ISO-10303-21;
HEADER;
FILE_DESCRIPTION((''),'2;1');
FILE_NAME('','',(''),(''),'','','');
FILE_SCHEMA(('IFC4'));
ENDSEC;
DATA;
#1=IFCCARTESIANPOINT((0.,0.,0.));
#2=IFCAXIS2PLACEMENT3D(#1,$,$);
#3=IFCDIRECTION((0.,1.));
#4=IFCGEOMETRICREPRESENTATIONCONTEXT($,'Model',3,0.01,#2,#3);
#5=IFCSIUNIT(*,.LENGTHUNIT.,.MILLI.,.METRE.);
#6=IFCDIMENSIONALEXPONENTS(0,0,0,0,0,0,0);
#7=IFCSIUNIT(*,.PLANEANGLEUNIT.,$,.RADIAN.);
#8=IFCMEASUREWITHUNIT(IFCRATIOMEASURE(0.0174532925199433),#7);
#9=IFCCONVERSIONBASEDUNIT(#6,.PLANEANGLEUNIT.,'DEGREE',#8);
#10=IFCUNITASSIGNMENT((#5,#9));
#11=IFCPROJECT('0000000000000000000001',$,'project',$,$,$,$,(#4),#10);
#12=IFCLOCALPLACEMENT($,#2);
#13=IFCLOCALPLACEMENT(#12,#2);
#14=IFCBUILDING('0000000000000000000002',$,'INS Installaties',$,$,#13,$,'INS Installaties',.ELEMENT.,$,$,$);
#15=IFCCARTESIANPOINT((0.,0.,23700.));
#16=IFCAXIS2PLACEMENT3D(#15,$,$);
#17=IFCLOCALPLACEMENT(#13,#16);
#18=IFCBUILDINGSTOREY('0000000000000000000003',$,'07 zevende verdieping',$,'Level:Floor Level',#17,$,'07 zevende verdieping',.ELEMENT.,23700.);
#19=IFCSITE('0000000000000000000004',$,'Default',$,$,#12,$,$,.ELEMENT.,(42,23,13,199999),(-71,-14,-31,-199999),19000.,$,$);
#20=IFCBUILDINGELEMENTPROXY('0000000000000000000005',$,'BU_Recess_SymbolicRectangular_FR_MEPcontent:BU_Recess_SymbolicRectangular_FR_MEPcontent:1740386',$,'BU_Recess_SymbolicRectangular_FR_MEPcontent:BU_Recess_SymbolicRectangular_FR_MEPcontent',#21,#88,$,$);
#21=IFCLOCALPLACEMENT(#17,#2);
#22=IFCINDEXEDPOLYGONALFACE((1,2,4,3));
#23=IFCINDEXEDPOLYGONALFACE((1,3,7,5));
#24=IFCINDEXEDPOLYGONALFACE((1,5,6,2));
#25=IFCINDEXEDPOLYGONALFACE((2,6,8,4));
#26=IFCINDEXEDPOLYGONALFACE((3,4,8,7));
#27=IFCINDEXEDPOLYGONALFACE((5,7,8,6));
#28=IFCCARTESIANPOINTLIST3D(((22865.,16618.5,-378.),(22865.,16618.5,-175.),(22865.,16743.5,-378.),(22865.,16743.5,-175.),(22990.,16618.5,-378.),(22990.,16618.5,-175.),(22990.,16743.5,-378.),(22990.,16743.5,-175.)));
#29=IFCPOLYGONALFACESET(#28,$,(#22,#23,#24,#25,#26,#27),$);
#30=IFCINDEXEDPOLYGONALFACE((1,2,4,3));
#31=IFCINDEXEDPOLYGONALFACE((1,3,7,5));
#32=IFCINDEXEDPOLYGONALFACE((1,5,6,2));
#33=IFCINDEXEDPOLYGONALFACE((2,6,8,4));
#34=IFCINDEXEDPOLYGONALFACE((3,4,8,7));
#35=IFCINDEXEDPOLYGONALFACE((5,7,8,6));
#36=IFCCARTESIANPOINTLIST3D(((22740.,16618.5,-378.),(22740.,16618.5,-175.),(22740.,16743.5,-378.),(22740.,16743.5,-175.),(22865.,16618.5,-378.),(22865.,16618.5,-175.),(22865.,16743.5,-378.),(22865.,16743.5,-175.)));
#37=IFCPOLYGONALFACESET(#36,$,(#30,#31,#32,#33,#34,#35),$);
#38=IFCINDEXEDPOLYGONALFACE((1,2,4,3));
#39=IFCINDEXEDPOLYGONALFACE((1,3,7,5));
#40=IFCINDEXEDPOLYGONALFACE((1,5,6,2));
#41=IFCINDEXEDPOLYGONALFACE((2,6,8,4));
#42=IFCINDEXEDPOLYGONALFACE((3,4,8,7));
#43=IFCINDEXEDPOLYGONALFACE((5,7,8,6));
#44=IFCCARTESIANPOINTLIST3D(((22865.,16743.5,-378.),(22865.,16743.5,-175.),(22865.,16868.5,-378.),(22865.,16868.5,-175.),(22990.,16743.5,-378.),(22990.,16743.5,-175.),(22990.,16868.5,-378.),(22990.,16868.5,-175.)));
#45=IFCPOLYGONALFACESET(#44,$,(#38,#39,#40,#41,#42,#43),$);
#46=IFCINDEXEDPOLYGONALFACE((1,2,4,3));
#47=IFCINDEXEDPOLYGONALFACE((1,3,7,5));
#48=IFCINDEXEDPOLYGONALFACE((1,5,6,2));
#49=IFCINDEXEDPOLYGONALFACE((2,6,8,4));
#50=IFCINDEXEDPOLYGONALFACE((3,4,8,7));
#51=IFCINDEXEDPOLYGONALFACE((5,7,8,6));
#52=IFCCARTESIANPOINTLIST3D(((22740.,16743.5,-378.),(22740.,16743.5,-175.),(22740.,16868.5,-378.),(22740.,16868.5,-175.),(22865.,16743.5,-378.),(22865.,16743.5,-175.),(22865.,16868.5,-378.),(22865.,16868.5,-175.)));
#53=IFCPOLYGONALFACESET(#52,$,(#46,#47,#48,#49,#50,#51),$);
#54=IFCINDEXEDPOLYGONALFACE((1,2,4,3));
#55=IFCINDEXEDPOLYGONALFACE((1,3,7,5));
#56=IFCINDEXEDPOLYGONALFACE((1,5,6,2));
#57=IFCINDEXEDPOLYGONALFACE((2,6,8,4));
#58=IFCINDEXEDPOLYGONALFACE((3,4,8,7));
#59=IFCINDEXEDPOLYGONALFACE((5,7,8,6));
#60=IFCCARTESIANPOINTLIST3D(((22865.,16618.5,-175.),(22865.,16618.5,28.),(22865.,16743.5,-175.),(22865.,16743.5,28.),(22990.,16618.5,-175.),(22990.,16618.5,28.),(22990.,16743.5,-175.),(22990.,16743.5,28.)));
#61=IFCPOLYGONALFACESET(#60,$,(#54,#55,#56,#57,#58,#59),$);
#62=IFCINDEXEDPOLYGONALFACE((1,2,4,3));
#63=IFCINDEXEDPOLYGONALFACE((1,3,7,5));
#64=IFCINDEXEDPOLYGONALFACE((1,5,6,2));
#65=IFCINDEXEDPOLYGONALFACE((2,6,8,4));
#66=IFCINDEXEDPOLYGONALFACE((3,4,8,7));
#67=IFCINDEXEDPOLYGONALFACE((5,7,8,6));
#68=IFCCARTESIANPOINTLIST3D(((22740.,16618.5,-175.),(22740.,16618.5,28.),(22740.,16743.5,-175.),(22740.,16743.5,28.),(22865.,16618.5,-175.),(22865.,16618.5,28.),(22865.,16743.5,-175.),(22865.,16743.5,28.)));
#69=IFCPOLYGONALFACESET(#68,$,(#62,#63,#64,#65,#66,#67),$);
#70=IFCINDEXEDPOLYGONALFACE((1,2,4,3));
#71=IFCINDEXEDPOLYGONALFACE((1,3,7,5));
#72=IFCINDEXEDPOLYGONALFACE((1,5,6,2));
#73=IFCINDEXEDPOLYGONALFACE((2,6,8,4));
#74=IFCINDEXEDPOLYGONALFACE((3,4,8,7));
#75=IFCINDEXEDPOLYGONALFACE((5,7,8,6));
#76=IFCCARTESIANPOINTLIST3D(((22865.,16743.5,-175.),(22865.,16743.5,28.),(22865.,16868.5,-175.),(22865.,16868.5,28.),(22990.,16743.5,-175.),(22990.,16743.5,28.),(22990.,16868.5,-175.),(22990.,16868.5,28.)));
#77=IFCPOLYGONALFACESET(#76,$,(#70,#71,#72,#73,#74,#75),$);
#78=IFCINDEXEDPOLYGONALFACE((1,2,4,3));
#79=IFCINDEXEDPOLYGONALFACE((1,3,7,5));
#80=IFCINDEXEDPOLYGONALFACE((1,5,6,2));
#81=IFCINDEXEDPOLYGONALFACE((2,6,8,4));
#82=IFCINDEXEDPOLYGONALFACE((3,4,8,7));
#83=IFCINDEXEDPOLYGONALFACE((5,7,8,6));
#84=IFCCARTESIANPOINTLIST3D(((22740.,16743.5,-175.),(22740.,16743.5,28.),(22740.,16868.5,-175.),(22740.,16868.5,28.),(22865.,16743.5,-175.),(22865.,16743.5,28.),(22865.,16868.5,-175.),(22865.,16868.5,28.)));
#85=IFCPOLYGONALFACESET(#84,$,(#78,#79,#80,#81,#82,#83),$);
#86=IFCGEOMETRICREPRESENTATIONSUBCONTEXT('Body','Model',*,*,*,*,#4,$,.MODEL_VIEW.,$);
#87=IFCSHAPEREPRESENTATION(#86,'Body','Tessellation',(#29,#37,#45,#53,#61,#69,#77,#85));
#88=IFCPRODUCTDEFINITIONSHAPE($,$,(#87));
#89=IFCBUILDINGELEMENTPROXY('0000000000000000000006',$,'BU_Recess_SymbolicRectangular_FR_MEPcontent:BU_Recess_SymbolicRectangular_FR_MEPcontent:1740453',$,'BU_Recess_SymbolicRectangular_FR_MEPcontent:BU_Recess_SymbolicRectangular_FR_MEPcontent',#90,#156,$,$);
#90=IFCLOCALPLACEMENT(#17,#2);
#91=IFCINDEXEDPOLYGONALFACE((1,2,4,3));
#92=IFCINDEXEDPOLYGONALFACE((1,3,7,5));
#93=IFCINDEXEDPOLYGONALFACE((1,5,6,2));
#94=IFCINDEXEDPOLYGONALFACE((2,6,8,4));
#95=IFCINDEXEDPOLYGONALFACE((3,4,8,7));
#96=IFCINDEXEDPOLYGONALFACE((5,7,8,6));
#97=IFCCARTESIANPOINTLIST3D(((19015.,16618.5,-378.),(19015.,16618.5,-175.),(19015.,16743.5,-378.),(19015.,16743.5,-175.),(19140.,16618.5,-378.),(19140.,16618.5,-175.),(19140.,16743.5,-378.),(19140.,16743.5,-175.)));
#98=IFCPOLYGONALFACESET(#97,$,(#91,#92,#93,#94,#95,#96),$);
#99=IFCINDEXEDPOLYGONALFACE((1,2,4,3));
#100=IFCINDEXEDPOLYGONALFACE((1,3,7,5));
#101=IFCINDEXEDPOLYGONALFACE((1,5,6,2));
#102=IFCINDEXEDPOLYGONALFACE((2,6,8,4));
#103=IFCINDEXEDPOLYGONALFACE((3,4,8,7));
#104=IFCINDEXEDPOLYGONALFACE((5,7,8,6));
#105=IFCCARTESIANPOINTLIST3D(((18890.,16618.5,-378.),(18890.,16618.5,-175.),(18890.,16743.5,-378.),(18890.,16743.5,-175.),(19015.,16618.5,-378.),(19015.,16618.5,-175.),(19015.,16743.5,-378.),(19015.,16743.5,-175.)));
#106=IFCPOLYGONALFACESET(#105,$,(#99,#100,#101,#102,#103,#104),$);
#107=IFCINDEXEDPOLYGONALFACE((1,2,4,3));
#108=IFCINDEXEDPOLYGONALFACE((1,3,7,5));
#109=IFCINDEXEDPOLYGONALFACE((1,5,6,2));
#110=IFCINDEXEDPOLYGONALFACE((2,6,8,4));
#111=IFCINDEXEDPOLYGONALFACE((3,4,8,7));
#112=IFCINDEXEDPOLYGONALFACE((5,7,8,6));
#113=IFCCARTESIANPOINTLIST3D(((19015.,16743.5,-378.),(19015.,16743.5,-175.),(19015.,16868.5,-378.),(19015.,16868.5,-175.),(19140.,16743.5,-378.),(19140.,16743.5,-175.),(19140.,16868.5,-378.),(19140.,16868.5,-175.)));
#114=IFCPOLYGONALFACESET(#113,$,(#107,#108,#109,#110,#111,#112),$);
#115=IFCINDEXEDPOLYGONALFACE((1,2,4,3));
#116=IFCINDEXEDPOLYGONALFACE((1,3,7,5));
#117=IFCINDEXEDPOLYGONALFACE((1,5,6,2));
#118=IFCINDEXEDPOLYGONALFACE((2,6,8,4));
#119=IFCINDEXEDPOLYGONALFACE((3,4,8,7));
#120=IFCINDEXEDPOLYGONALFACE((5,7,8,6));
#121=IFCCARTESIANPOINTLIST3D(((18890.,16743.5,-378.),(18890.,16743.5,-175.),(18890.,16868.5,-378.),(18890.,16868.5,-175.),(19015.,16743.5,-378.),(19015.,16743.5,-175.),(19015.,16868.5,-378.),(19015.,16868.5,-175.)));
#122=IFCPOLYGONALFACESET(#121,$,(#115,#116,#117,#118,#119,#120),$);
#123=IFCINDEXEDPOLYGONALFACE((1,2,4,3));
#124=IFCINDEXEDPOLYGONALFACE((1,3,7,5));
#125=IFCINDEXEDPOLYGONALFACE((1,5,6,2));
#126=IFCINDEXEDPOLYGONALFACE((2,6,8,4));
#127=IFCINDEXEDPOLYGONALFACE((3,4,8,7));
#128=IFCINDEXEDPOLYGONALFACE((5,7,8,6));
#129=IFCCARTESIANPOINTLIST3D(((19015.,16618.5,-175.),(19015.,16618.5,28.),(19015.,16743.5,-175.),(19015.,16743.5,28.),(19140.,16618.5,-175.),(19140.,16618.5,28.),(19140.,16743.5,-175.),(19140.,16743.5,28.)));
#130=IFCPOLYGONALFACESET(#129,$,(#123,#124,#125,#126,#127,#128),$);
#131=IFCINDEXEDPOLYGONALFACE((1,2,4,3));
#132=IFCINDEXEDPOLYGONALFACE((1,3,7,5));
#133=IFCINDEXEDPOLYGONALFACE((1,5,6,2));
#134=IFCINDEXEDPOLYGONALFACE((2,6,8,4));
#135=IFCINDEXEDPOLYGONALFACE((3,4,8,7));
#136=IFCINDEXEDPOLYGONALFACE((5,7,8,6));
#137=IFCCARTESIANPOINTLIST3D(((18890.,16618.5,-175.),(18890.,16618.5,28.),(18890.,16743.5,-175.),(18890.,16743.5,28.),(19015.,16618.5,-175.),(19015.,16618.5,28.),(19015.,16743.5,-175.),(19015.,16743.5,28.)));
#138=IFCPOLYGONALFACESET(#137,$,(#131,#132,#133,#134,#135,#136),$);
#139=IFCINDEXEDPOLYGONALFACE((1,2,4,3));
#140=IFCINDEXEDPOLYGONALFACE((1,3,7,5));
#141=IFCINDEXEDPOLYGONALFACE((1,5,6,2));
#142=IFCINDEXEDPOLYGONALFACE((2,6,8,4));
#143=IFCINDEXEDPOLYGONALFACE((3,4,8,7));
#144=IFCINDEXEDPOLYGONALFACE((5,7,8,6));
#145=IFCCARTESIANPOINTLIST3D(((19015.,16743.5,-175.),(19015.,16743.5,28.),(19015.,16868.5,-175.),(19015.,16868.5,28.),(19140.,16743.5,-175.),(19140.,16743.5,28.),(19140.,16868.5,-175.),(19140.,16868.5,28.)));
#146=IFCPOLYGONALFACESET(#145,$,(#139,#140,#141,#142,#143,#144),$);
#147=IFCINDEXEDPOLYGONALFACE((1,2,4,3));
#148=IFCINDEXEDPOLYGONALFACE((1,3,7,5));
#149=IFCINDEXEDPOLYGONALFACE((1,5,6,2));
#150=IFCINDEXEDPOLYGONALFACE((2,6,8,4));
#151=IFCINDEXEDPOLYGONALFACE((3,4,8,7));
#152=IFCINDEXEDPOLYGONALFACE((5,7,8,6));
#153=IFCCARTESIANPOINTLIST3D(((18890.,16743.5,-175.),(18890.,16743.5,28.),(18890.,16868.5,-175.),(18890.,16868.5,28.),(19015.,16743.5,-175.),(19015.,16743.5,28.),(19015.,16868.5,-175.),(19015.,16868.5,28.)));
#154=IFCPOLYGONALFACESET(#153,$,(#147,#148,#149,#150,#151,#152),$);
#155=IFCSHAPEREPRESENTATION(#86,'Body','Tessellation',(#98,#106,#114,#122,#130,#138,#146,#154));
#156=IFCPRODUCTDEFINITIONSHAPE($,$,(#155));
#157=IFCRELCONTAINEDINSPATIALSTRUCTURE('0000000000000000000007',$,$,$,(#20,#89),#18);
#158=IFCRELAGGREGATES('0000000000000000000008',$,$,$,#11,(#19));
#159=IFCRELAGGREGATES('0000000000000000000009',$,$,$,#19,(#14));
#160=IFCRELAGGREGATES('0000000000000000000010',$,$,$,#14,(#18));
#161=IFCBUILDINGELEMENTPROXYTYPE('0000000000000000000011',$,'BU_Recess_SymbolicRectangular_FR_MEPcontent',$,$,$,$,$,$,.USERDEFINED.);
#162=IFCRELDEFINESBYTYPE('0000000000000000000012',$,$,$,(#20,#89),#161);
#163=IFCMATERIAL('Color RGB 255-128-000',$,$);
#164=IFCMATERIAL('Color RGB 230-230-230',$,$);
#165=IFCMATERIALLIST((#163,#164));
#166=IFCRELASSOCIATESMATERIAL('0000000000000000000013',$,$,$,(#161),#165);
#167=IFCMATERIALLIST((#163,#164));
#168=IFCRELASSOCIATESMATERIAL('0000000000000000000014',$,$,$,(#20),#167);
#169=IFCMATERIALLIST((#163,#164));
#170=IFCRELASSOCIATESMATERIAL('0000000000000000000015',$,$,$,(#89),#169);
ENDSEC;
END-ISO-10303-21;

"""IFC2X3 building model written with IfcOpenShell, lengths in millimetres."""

from ifc_helpers import new_model, entity, si_unit, converted_unit, direction, frame, frame_2d, origin, origin_2d_with_axis, place, context, subcontext, project, spatial, rectangle, extrude, source, transform, mapped, material, material_list, type_object, type_shapes, element, save


model = new_model("IFC2X3")

# Units and contexts
model_context = context("Model", 3, precision=0.01, world=origin(), true_north=direction((0.0, 1.0)))
body_context = subcontext(model_context, "Body", "Model", "MODEL_VIEW")
ifc_project = project(units=[si_unit("LENGTHUNIT", "METRE", prefix="MILLI"), converted_unit("PLANEANGLEUNIT", "DEGREE", entity("IfcRatioMeasure", 0.0174532925199433), si_unit("PLANEANGLEUNIT", "RADIAN"), dimensions=[0, 0, 0, 0, 0, 0, 0])], contexts=[model_context])

# Site, building, storey
site_placement = place(None, origin())
site = spatial("IfcSite", under=ifc_project, at=site_placement, Name="Default", CompositionType="ELEMENT", RefLatitude=(42, 23, 13, 199999), RefLongitude=(-71, -14, -31, -199999), RefElevation=19000.0)
building_placement = place(site_placement, origin())
building = spatial("IfcBuilding", under=site, at=building_placement, Name="INS Installaties", LongName="INS Installaties", CompositionType="ELEMENT")
storey_placement = place(building_placement, frame((0.0, 0.0, 23700.0)))
storey = spatial("IfcBuildingStorey", under=building, at=storey_placement, Name="07 zevende verdieping", ObjectType="Level:Floor Level", LongName="07 zevende verdieping", CompositionType="ELEMENT", Elevation=23700.0)

# Building element proxies
ifc_material_1 = material(Name="Color RGB 255-128-000")
ifc_material_2 = material(Name="Color RGB 230-230-230")
ifc_material_list_1 = material_list([ifc_material_1, ifc_material_2])
ifc_material_list_2 = material_list([ifc_material_1, ifc_material_2])
building_element_proxy_type_1 = type_object("IfcBuildingElementProxyType", Name="BU_Recess_SymbolicRectangular_FR_MEPcontent", PredefinedType="USERDEFINED", material=ifc_material_list_2)
shared_shape_1 = source(origin(), body_context, "Body", "SweptSolid", [
    extrude(rectangle(XDim=125.0, YDim=125.0, at=frame_2d((0.0, 0.0), x_axis=(1.0, 0.0))), frame((62.5, -62.5, -403.0)), (0.0, 0.0, 1.0), 203.0),
    extrude(rectangle(XDim=125.0, YDim=125.0, at=origin_2d_with_axis()), frame((-62.5, -62.5, -403.0), z_axis=(0.0, 0.0, 1.0), x_axis=(0.0, 1.0, 0.0)), (0.0, 0.0, 1.0), 203.0),
    extrude(rectangle(XDim=125.0, YDim=125.0, at=origin_2d_with_axis()), frame((62.5, 62.5, -403.0), z_axis=(0.0, 0.0, 1.0), x_axis=(0.0, -1.0, 0.0)), (0.0, 0.0, 1.0), 203.0),
    extrude(rectangle(XDim=125.0, YDim=125.0, at=origin_2d_with_axis()), frame((-62.5, 62.5, -403.0), z_axis=(0.0, 0.0, 1.0), x_axis=(-1.0, 0.0, 0.0)), (0.0, 0.0, 1.0), 203.0),
    extrude(rectangle(XDim=125.0, YDim=125.0, at=frame_2d((0.0, 0.0), x_axis=(1.0, 0.0))), frame((62.5, -62.5, -200.0)), (0.0, 0.0, 1.0), 203.0),
    extrude(rectangle(XDim=125.0, YDim=125.0, at=frame_2d((0.0, 0.0), x_axis=(1.0, 0.0))), frame((-62.5, -62.5, -200.0), z_axis=(0.0, 0.0, 1.0), x_axis=(0.0, 1.0, 0.0)), (0.0, 0.0, 1.0), 203.0),
    extrude(rectangle(XDim=125.0, YDim=125.0, at=frame_2d((0.0, 0.0), x_axis=(1.0, 0.0))), frame((62.5, 62.5, -200.0), z_axis=(0.0, 0.0, 1.0), x_axis=(0.0, -1.0, 0.0)), (0.0, 0.0, 1.0), 203.0),
    extrude(rectangle(XDim=125.0, YDim=125.0, at=origin_2d_with_axis()), frame((-62.5, 62.5, -200.0), z_axis=(0.0, 0.0, 1.0), x_axis=(-1.0, 0.0, 0.0)), (0.0, 0.0, 1.0), 203.0),
])
type_shapes(building_element_proxy_type_1, [shared_shape_1])
proxy_1_placement = place(storey_placement, frame((22865.0, 16743.5, 25.0)))
element("IfcBuildingElementProxy", 1, at=proxy_1_placement, inside=storey, type_object=building_element_proxy_type_1, material=ifc_material_list_1, Name="BU_Recess_SymbolicRectangular_FR_MEPcontent:BU_Recess_SymbolicRectangular_FR_MEPcontent:1740386", ObjectType="BU_Recess_SymbolicRectangular_FR_MEPcontent:BU_Recess_SymbolicRectangular_FR_MEPcontent", context=body_context, shape_type="MappedRepresentation", body=[
    mapped(shared_shape_1, transform((0.0, 0.0, 0.0), scale=1.0)),
])
ifc_material_list_3 = material_list([ifc_material_1, ifc_material_2])
proxy_2_placement = place(storey_placement, frame((19015.0, 16743.5, 25.0)))
element("IfcBuildingElementProxy", 2, at=proxy_2_placement, inside=storey, type_object=building_element_proxy_type_1, material=ifc_material_list_3, Name="BU_Recess_SymbolicRectangular_FR_MEPcontent:BU_Recess_SymbolicRectangular_FR_MEPcontent:1740453", ObjectType="BU_Recess_SymbolicRectangular_FR_MEPcontent:BU_Recess_SymbolicRectangular_FR_MEPcontent", context=body_context, shape_type="MappedRepresentation", body=[
    mapped(shared_shape_1, transform((0.0, 0.0, 0.0), scale=1.0)),
])

save(model, "model.ifc")
